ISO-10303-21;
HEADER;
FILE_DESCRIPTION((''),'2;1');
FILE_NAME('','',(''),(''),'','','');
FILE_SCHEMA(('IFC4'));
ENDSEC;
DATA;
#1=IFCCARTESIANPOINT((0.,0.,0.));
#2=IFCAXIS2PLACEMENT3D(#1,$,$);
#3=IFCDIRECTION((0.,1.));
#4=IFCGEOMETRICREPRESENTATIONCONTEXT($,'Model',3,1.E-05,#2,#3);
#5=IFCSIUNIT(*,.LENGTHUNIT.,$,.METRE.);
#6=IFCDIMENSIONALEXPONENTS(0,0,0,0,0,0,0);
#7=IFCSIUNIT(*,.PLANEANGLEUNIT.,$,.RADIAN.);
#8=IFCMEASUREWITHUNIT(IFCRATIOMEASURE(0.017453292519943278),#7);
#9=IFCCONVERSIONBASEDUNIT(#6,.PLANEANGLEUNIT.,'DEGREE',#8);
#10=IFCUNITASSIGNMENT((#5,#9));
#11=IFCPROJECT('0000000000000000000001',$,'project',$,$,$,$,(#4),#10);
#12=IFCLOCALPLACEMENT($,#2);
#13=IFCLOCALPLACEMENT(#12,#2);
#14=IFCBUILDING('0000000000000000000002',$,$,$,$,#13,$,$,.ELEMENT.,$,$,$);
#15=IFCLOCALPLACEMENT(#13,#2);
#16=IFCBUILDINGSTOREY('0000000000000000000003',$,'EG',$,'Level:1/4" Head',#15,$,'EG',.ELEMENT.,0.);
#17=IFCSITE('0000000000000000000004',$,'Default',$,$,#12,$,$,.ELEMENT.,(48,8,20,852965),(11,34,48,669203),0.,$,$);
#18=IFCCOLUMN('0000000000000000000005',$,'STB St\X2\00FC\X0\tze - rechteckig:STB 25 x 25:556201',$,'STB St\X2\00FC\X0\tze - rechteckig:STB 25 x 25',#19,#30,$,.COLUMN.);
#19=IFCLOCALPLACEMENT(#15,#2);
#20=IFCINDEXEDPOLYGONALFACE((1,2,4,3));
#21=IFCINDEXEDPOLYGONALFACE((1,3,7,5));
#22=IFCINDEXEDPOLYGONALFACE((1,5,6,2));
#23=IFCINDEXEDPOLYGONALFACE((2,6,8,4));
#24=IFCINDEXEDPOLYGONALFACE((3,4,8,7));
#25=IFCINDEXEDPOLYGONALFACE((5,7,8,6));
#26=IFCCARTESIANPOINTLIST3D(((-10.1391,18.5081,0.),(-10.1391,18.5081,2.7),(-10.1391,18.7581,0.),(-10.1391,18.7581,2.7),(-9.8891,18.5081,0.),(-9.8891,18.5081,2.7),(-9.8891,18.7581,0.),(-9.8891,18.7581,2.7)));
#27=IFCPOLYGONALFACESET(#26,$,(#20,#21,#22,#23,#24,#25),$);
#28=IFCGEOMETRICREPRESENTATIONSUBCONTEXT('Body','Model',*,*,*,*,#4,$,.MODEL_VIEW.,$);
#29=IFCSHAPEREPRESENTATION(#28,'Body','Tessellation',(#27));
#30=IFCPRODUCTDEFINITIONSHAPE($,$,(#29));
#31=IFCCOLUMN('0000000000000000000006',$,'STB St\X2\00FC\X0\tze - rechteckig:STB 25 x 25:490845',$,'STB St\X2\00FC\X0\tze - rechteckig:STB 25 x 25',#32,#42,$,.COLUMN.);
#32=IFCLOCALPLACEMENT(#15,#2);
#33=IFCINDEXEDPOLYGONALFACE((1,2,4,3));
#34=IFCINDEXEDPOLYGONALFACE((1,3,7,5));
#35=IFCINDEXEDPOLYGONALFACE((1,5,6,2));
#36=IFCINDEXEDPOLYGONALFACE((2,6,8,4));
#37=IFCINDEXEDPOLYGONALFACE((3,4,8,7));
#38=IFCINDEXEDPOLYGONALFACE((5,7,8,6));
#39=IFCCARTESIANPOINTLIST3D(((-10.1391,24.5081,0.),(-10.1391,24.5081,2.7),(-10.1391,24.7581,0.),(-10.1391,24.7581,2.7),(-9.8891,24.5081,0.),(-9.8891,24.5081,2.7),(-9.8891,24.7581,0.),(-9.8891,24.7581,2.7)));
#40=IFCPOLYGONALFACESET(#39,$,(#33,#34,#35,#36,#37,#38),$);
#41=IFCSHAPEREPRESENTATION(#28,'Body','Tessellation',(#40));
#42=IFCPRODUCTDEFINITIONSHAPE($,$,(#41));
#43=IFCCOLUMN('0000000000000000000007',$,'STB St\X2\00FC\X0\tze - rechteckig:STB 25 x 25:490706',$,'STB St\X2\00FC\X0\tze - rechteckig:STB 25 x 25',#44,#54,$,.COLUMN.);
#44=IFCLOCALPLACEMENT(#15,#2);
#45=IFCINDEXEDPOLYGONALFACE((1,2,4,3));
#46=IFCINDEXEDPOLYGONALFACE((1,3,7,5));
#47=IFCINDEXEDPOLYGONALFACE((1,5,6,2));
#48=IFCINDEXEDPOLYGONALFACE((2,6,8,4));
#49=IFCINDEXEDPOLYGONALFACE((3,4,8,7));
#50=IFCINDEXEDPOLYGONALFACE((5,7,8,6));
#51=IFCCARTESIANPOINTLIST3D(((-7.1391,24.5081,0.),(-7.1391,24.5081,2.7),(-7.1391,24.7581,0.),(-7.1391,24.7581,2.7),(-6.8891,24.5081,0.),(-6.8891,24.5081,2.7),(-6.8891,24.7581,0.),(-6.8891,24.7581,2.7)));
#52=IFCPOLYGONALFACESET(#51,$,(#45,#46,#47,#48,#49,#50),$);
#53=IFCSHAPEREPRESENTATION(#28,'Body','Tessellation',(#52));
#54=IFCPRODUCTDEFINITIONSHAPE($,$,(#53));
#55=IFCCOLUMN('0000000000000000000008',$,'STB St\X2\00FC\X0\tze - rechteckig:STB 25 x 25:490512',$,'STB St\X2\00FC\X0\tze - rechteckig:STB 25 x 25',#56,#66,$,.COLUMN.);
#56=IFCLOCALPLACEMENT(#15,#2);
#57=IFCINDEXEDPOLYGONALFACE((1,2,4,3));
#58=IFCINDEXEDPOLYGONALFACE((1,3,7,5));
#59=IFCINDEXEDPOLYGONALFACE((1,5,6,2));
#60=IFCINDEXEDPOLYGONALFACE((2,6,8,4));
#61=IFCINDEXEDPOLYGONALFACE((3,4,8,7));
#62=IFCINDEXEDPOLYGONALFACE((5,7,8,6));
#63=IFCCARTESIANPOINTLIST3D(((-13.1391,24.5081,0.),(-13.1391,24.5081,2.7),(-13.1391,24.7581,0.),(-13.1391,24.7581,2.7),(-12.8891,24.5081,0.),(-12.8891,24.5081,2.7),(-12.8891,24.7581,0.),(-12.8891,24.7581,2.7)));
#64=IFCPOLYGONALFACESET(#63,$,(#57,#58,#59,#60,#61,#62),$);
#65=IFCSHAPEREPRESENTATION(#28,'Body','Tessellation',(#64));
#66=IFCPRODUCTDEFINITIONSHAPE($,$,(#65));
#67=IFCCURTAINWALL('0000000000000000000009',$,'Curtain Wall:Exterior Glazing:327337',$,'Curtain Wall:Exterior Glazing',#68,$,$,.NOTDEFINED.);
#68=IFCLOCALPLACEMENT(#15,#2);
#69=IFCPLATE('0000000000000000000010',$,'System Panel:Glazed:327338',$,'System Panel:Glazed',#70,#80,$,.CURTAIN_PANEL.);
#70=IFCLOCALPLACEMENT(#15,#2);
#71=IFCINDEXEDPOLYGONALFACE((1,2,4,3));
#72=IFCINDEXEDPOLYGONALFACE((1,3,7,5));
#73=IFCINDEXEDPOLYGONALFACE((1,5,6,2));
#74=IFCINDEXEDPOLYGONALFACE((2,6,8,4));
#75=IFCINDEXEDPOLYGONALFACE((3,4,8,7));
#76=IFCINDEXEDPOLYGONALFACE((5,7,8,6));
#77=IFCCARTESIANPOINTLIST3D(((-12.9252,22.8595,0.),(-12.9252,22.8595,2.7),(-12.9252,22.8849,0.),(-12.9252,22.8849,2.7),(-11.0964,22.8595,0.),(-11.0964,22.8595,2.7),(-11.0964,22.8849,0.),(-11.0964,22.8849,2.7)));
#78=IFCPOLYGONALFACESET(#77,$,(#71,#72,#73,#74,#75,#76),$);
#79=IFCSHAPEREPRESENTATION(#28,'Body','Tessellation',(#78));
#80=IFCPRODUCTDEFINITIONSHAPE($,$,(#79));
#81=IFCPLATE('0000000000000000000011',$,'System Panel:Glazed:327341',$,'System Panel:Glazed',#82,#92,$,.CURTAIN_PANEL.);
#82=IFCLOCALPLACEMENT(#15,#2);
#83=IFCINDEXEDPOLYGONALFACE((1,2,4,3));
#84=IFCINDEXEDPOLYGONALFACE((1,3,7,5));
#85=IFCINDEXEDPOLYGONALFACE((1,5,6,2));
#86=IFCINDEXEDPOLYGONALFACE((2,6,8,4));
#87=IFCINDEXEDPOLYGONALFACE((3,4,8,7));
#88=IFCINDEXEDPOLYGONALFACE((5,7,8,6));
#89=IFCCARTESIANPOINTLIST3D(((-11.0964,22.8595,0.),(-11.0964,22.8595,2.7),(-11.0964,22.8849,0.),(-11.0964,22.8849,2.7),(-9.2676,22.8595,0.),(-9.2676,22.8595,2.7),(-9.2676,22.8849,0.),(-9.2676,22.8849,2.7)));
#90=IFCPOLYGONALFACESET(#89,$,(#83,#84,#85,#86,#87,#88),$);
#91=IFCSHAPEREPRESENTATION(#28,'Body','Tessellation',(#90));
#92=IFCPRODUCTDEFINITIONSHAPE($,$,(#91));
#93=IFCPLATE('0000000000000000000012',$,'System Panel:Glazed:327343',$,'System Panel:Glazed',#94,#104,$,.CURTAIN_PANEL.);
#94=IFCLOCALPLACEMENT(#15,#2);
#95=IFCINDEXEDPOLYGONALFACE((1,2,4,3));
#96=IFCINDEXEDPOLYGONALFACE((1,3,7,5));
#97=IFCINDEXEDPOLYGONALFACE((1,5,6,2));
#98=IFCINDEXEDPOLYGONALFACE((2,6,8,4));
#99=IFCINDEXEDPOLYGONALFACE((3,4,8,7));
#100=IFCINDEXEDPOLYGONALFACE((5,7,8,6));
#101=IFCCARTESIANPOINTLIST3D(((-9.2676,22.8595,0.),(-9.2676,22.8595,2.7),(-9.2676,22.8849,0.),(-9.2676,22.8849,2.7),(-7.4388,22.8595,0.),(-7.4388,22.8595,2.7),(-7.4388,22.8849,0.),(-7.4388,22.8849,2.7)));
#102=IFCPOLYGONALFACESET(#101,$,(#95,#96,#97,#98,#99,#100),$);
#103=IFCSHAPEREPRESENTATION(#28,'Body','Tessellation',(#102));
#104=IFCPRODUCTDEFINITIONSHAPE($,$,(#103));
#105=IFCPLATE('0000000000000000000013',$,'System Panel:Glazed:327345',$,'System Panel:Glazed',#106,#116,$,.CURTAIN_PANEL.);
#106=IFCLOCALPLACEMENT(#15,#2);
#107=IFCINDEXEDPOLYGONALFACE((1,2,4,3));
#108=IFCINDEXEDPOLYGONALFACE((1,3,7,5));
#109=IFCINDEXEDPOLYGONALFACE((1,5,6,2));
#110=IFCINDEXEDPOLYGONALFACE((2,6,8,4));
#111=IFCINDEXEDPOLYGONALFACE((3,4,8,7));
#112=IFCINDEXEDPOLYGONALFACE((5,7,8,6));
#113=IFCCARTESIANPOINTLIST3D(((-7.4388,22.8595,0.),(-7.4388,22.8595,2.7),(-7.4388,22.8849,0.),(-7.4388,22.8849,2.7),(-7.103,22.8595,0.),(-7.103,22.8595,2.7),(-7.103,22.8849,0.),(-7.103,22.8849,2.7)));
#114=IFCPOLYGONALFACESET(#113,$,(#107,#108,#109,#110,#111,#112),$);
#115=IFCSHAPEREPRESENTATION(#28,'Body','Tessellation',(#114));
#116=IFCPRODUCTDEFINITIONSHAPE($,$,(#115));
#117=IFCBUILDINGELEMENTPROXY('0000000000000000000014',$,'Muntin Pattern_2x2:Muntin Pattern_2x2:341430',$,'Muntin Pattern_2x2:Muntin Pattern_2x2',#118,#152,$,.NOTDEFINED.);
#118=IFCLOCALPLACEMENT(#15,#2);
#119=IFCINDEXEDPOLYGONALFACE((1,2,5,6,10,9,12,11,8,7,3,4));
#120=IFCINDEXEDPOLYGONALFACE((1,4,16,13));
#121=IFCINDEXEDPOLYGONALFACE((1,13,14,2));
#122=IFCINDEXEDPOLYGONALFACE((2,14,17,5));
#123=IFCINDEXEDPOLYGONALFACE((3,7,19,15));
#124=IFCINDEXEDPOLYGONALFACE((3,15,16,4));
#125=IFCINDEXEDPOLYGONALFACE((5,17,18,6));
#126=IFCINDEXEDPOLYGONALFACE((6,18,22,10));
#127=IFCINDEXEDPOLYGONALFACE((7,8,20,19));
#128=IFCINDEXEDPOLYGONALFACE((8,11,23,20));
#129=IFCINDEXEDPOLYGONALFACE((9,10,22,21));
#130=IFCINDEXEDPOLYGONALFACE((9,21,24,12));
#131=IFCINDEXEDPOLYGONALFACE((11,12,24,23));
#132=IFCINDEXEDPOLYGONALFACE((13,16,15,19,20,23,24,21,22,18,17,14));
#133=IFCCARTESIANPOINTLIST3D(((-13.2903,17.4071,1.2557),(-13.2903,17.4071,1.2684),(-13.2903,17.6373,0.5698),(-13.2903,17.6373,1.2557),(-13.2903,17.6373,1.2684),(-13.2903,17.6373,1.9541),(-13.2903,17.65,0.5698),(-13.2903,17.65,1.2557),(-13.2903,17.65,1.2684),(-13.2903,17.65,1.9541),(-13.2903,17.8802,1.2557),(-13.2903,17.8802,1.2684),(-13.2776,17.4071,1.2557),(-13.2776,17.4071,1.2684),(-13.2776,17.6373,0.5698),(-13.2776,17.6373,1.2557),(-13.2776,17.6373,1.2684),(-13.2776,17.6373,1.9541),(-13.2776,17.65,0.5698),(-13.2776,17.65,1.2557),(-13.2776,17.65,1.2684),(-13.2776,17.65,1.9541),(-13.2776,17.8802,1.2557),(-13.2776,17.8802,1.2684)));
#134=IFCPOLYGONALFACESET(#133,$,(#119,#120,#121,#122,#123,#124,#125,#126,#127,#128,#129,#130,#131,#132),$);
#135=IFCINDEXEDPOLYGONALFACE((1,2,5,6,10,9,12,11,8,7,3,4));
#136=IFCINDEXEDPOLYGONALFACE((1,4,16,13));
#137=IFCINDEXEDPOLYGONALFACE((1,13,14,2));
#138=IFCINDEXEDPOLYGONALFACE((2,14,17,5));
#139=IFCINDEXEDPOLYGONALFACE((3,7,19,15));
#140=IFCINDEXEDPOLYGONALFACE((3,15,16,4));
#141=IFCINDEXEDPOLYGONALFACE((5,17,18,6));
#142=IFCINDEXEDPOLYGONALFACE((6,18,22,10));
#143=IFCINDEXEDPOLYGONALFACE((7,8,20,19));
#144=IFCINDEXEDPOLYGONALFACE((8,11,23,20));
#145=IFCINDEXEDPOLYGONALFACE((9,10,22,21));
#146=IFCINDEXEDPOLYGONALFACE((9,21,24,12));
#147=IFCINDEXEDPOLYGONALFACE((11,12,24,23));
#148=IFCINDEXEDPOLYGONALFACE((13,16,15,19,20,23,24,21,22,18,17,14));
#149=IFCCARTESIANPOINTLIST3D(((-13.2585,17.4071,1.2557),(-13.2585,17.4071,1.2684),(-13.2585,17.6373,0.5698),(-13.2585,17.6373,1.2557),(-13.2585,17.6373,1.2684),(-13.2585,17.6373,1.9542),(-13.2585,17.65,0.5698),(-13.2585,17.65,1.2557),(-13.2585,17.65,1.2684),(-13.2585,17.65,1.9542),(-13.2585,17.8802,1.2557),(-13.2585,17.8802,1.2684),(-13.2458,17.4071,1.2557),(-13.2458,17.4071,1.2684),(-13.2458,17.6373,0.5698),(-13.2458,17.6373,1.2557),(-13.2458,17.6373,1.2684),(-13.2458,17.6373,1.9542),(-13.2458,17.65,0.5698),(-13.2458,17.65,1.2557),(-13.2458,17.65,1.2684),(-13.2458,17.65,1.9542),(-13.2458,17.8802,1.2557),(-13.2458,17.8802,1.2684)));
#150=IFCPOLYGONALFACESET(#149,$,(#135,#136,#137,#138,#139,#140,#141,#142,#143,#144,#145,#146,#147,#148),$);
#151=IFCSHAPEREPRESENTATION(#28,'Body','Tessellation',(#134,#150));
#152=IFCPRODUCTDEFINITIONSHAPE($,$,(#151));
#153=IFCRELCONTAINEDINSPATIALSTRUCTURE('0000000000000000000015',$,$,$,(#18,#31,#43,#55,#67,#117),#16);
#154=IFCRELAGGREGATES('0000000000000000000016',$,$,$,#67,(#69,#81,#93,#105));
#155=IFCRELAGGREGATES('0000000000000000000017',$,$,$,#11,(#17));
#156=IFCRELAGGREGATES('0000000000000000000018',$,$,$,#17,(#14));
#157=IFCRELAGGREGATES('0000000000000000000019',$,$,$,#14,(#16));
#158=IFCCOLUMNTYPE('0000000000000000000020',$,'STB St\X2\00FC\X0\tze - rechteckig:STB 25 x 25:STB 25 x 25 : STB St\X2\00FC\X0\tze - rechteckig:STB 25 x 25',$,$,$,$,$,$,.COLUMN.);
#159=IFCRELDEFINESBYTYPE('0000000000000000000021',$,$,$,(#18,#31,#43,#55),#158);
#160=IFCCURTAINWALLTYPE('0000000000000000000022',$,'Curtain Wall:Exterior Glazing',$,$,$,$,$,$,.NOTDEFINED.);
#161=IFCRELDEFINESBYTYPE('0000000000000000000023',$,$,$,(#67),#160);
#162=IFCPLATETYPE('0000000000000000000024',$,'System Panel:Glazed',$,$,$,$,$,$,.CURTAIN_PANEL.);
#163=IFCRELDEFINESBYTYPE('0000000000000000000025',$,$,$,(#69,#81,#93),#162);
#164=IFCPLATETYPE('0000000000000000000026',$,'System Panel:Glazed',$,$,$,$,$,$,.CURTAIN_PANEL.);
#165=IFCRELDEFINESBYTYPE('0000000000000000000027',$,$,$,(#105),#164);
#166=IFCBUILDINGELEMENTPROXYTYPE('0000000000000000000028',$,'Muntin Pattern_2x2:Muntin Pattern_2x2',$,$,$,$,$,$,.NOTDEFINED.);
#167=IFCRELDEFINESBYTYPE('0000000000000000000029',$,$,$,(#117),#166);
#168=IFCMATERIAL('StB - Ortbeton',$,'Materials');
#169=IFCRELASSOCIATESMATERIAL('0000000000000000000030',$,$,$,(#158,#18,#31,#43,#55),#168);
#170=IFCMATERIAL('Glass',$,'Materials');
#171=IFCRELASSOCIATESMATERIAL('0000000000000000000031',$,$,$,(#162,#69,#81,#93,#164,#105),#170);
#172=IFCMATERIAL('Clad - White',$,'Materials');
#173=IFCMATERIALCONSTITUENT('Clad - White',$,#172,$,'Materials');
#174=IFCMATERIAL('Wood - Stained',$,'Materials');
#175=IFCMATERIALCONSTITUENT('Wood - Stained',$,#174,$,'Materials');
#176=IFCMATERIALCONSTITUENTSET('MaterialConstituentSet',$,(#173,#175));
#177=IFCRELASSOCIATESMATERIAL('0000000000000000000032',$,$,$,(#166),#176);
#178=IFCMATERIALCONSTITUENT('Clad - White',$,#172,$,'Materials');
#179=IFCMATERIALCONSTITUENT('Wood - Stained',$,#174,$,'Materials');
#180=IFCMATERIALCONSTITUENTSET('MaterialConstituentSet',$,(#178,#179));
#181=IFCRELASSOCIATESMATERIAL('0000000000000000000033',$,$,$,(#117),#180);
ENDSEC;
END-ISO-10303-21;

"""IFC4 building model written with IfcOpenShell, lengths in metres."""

from ifc_helpers import new_model, entity, si_unit, converted_unit, direction, frame, origin, place, context, subcontext, project, spatial, indexed_curve, outline, extrude, source, transform, mapped, material, constituent, constituent_set, type_object, type_shapes, element, aggregate, save


model = new_model("IFC4")

# Units and contexts
model_context = context("Model", 3, precision=1e-05, world=origin(), true_north=direction((0.0, 1.0)))
body_context = subcontext(model_context, "Body", "Model", "MODEL_VIEW")
ifc_project = project(units=[si_unit("LENGTHUNIT", "METRE"), converted_unit("PLANEANGLEUNIT", "DEGREE", entity("IfcRatioMeasure", 0.017453292519943278), si_unit("PLANEANGLEUNIT", "RADIAN"), dimensions=[0, 0, 0, 0, 0, 0, 0])], contexts=[model_context])

# Site, building, storey
site_placement = place(None, origin())
site = spatial("IfcSite", under=ifc_project, at=site_placement, Name="Default", CompositionType="ELEMENT", RefLatitude=(48, 8, 20, 852965), RefLongitude=(11, 34, 48, 669203), RefElevation=0.0)
building_placement = place(site_placement, origin())
building = spatial("IfcBuilding", under=site, at=building_placement, CompositionType="ELEMENT")
storey_placement = place(building_placement, origin())
storey = spatial("IfcBuildingStorey", under=building, at=storey_placement, Name="EG", ObjectType="Level:1/4\" Head", LongName="EG", CompositionType="ELEMENT", Elevation=0.0)

# Columns
ifc_material_1 = material(Name="StB - Ortbeton", Category="Materials")
column_type = type_object("IfcColumnType", Name="STB Stütze - rechteckig:STB 25 x 25:STB 25 x 25 : STB Stütze - rechteckig:STB 25 x 25", PredefinedType="COLUMN", material=ifc_material_1)
shared_shape_1 = source(origin(), body_context, "Body", "SweptSolid", [
    extrude(outline(indexed_curve([(-0.125, -0.125), (0.125, -0.125), (0.125, 0.125), (-0.125, 0.125), (-0.125, -0.125)], self_intersect=False)), frame((0.0, 0.0, 0.0), z_axis=(0.0, 0.0, 1.0), x_axis=(0.0, -1.0, 0.0)), (0.0, 0.0, 1.0), 2.7),
])
type_shapes(column_type, [shared_shape_1])
for number, where, name in (
    (1, (-10.0141, 18.6331, 0.0), "STB Stütze - rechteckig:STB 25 x 25:556201"),
    (2, (-10.0141, 24.6331, 0.0), "STB Stütze - rechteckig:STB 25 x 25:490845"),
    (3, (-7.0141, 24.6331, 0.0), "STB Stütze - rechteckig:STB 25 x 25:490706"),
    (4, (-13.0141, 24.6331, 0.0), "STB Stütze - rechteckig:STB 25 x 25:490512"),
):
    element("IfcColumn", number, at=place(storey_placement, frame(where)), inside=storey, type_object=column_type, material=ifc_material_1, Name=name, ObjectType="STB Stütze - rechteckig:STB 25 x 25", PredefinedType="COLUMN", context=body_context, shape_type="MappedRepresentation", body=[
        mapped(shared_shape_1, transform((0.0, 0.0, 0.0), scale=1.0)),
    ])

# Curtain wall, plates
curtain_wall_type = type_object("IfcCurtainWallType", Name="Curtain Wall:Exterior Glazing", PredefinedType="NOTDEFINED")
curtain_wall_placement = place(storey_placement, origin())
curtain_wall = element("IfcCurtainWall", 5, at=curtain_wall_placement, inside=storey, type_object=curtain_wall_type, Name="Curtain Wall:Exterior Glazing:327337", ObjectType="Curtain Wall:Exterior Glazing", PredefinedType="NOTDEFINED")
ifc_material_2 = material(Name="Glass", Category="Materials")
plate_type_1 = type_object("IfcPlateType", Name="System Panel:Glazed", PredefinedType="CURTAIN_PANEL", material=ifc_material_2)
shared_shape_2 = source(origin(), body_context, "Body", "SweptSolid", [
    extrude(outline(indexed_curve([(-0.0127, -0.9144), (0.0127, -0.9144), (0.0127, 0.9144), (-0.0127, 0.9144), (-0.0127, -0.9144)], self_intersect=False)), frame((0.0, 0.0317, 0.0), z_axis=(0.0, 0.0, 1.0), x_axis=(0.0, 1.0, 0.0)), (0.0, 0.0, 1.0), 2.7),
])
type_shapes(plate_type_1, [shared_shape_2])
plate_1_placement = place(curtain_wall_placement, frame((-12.0108, 22.8405, 0.0)))
plate_1 = element("IfcPlate", 6, at=plate_1_placement, type_object=plate_type_1, material=ifc_material_2, Name="System Panel:Glazed:327338", ObjectType="System Panel:Glazed", PredefinedType="CURTAIN_PANEL", context=body_context, shape_type="MappedRepresentation", body=[
    mapped(shared_shape_2, transform((0.0, 0.0, 0.0), scale=1.0)),
])
plate_2_placement = place(curtain_wall_placement, frame((-10.182, 22.8405, 0.0)))
plate_2 = element("IfcPlate", 7, at=plate_2_placement, type_object=plate_type_1, material=ifc_material_2, Name="System Panel:Glazed:327341", ObjectType="System Panel:Glazed", PredefinedType="CURTAIN_PANEL", context=body_context, shape_type="MappedRepresentation", body=[
    mapped(shared_shape_2, transform((0.0, 0.0, 0.0), scale=1.0)),
])
plate_3_placement = place(curtain_wall_placement, frame((-8.3532, 22.8405, 0.0)))
plate_3 = element("IfcPlate", 8, at=plate_3_placement, type_object=plate_type_1, material=ifc_material_2, Name="System Panel:Glazed:327343", ObjectType="System Panel:Glazed", PredefinedType="CURTAIN_PANEL", context=body_context, shape_type="MappedRepresentation", body=[
    mapped(shared_shape_2, transform((0.0, 0.0, 0.0), scale=1.0)),
])
plate_type_2 = type_object("IfcPlateType", Name="System Panel:Glazed", PredefinedType="CURTAIN_PANEL", material=ifc_material_2)
shared_shape_3 = source(origin(), body_context, "Body", "SweptSolid", [
    extrude(outline(indexed_curve([(-0.0127, -0.1679), (0.0127, -0.1679), (0.0127, 0.1679), (-0.0127, 0.1679), (-0.0127, -0.1679)], self_intersect=False)), frame((0.0, 0.0318, 0.0), z_axis=(0.0, 0.0, 1.0), x_axis=(0.0, 1.0, 0.0)), (0.0, 0.0, 1.0), 2.7),
])
type_shapes(plate_type_2, [shared_shape_3])
plate_4_placement = place(curtain_wall_placement, frame((-7.2709, 22.8405, 0.0)))
plate_4 = element("IfcPlate", 9, at=plate_4_placement, type_object=plate_type_2, material=ifc_material_2, Name="System Panel:Glazed:327345", ObjectType="System Panel:Glazed", PredefinedType="CURTAIN_PANEL", context=body_context, shape_type="MappedRepresentation", body=[
    mapped(shared_shape_3, transform((0.0, 0.0, 0.0), scale=1.0)),
])
aggregate(curtain_wall, [plate_1, plate_2, plate_3, plate_4])

# Building element proxy
ifc_material_3 = material(Name="Clad - White", Category="Materials")
ifc_constituent_1 = constituent(ifc_material_3, Name="Clad - White", Category="Materials")
ifc_material_4 = material(Name="Wood - Stained", Category="Materials")
ifc_constituent_2 = constituent(ifc_material_4, Name="Wood - Stained", Category="Materials")
ifc_constituent_set_1 = constituent_set(constituents=[ifc_constituent_1, ifc_constituent_2], Name="MaterialConstituentSet")
ifc_constituent_3 = constituent(ifc_material_3, Name="Clad - White", Category="Materials")
ifc_constituent_4 = constituent(ifc_material_4, Name="Wood - Stained", Category="Materials")
ifc_constituent_set_2 = constituent_set(constituents=[ifc_constituent_3, ifc_constituent_4], Name="MaterialConstituentSet")
building_element_proxy_type_1 = type_object("IfcBuildingElementProxyType", Name="Muntin Pattern_2x2:Muntin Pattern_2x2", PredefinedType="NOTDEFINED", material=ifc_constituent_set_2)
shared_shape_4 = source(origin(), body_context, "Body", "SweptSolid", [
    extrude(outline(indexed_curve([(0.0064, -0.0064), (0.6921, -0.0064), (0.6921, 0.0063), (0.0064, 0.0063), (0.0064, 0.2365), (-0.0063, 0.2365), (-0.0063, 0.0063), (-0.6922, 0.0063), (-0.6922, -0.0064), (-0.0063, -0.0064), (-0.0063, -0.2365), (0.0064, -0.2365), (0.0064, -0.0064)], self_intersect=False)), frame((0.0, -0.0222, 0.6921), z_axis=(0.0, 1.0, 0.0), x_axis=(0.0, 0.0, 1.0)), (0.0, 0.0, 1.0), 0.0127),
    extrude(outline(indexed_curve([(0.0064, -0.0064), (0.6922, -0.0064), (0.6922, 0.0063), (0.0064, 0.0063), (0.0064, 0.2365), (-0.0063, 0.2365), (-0.0063, 0.0063), (-0.6922, 0.0063), (-0.6922, -0.0064), (-0.0063, -0.0064), (-0.0063, -0.2365), (0.0064, -0.2365), (0.0064, -0.0064)], self_intersect=False)), frame((0.0, 0.0095, 0.6922), z_axis=(0.0, 1.0, 0.0), x_axis=(0.0, 0.0, 1.0)), (0.0, 0.0, 1.0), 0.0127),
])
type_shapes(building_element_proxy_type_1, [shared_shape_4])
proxy_1_placement = place(storey_placement, frame((-13.2681, 17.6437, 0.5699), z_axis=(0.0, 0.0, 1.0), x_axis=(0.0, -1.0, 0.0)))
element("IfcBuildingElementProxy", 10, at=proxy_1_placement, inside=storey, type_object=building_element_proxy_type_1, material=ifc_constituent_set_1, Name="Muntin Pattern_2x2:Muntin Pattern_2x2:341430", ObjectType="Muntin Pattern_2x2:Muntin Pattern_2x2", PredefinedType="NOTDEFINED", context=body_context, shape_type="MappedRepresentation", body=[
    mapped(shared_shape_4, transform((0.0, 0.0, 0.0), scale=1.0)),
])

save(model, "model.ifc")
